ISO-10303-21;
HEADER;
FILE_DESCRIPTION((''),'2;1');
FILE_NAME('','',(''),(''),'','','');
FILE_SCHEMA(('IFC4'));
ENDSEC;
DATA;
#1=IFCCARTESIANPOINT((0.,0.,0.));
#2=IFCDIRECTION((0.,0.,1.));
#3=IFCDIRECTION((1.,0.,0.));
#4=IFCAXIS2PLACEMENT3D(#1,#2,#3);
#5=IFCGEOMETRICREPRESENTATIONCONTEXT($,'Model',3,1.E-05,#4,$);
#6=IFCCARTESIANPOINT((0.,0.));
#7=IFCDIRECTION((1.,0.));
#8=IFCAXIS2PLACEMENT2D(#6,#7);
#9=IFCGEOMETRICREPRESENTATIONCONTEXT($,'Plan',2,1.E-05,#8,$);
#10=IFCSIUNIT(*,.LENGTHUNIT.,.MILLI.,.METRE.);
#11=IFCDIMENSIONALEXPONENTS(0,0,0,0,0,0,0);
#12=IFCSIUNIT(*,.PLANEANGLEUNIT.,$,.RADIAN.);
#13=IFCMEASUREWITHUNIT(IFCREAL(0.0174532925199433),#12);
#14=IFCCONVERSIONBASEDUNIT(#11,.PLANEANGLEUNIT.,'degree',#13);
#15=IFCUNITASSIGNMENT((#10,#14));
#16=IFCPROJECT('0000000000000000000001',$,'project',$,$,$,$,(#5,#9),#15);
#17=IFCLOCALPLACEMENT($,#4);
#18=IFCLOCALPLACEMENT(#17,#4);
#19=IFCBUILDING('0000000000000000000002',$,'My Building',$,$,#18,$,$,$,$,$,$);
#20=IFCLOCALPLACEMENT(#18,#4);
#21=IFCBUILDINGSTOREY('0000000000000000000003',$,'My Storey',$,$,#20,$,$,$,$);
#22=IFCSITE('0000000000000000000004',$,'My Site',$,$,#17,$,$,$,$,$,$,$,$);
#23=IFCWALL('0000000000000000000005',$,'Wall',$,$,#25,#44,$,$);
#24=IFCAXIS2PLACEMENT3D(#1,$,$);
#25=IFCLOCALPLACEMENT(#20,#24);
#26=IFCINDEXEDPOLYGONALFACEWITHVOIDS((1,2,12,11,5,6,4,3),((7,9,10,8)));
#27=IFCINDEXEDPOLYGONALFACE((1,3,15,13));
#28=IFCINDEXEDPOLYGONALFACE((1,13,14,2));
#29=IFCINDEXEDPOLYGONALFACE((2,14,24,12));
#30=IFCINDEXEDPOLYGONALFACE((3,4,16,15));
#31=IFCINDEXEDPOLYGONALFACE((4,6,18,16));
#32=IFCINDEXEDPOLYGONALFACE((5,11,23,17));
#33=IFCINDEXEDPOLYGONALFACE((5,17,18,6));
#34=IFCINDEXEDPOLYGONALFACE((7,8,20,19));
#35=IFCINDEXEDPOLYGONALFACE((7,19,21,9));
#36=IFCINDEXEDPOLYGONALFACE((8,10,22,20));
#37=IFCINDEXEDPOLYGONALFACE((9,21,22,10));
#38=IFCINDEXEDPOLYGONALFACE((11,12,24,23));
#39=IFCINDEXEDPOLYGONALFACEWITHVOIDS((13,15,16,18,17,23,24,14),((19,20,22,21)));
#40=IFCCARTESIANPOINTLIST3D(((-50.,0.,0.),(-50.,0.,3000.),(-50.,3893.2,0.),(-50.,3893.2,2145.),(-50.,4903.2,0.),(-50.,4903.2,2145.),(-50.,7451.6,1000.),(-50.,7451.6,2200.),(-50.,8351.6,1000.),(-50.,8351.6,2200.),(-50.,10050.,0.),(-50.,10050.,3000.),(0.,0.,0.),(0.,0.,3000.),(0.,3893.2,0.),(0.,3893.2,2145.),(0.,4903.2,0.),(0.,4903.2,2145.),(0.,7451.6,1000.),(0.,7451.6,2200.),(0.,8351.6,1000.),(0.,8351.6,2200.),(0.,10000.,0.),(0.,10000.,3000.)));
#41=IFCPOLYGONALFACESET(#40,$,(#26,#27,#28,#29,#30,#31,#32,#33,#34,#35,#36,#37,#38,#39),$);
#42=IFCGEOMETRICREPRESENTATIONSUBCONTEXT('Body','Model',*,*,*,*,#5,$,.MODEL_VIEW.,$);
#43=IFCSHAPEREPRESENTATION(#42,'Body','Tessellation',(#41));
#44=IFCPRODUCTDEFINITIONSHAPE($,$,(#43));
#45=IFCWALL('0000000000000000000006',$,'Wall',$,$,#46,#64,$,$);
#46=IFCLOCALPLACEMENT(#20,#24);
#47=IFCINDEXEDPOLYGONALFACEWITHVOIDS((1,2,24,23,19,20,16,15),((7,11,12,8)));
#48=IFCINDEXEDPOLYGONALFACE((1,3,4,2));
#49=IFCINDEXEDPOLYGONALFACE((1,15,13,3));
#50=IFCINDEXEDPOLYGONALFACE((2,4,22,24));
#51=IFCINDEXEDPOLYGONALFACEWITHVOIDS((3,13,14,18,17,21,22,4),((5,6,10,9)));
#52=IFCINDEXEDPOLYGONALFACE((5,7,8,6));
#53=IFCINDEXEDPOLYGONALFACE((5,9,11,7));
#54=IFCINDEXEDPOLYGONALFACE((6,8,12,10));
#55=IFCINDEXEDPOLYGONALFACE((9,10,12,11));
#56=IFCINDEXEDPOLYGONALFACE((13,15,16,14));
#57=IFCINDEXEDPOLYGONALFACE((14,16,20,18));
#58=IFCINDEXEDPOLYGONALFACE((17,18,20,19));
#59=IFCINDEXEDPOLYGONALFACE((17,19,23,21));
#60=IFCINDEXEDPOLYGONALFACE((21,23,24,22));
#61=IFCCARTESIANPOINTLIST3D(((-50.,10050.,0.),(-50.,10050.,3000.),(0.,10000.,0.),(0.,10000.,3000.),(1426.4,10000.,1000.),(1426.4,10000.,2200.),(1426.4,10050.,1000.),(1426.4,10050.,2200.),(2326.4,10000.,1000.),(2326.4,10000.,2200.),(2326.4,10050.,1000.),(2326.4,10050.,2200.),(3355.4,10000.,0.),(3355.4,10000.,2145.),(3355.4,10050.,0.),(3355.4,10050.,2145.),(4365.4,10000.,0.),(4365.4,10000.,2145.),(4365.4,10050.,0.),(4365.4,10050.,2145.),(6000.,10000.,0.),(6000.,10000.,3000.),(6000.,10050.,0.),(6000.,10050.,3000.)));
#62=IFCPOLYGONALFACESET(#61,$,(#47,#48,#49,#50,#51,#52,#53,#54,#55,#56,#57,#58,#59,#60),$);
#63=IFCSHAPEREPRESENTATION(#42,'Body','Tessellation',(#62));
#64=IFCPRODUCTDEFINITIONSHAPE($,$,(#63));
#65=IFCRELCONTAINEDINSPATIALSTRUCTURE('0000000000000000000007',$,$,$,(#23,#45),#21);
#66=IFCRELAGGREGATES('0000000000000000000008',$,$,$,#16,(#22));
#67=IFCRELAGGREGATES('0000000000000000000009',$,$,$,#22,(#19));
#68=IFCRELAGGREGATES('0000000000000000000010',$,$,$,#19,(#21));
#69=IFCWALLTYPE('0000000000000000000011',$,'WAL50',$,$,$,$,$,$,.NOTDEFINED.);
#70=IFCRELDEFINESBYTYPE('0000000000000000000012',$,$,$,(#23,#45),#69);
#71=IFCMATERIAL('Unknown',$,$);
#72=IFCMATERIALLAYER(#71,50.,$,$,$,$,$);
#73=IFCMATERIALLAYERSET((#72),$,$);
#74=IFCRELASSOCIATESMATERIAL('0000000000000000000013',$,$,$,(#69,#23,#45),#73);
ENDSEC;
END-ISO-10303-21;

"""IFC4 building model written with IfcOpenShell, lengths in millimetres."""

from ifc_helpers import new_model, entity, si_unit, converted_unit, frame, origin_with_axes, origin_2d_with_axis, place, context, subcontext, project, spatial, line, indexed_curve, outline, extrude, source, transform, mapped, material, layer, layer_set, layer_usage, type_object, element, save


model = new_model("IFC4")

# Units and contexts
model_context = context("Model", 3, precision=1e-05, world=origin_with_axes())
plan_context = context("Plan", 2, precision=1e-05, world=origin_2d_with_axis())
body_context = subcontext(model_context, "Body", "Model", "MODEL_VIEW")
ifc_project = project(units=[si_unit("LENGTHUNIT", "METRE", prefix="MILLI"), converted_unit("PLANEANGLEUNIT", "degree", entity("IfcReal", 0.0174532925199433), si_unit("PLANEANGLEUNIT", "RADIAN"), dimensions=[0, 0, 0, 0, 0, 0, 0])], contexts=[model_context, plan_context])

# Site, building, storey
site_placement = place(None, origin_with_axes())
site = spatial("IfcSite", under=ifc_project, at=site_placement, Name="My Site")
building_placement = place(site_placement, origin_with_axes())
building = spatial("IfcBuilding", under=site, at=building_placement, Name="My Building")
storey_placement = place(building_placement, origin_with_axes())
storey = spatial("IfcBuildingStorey", under=building, at=storey_placement, Name="My Storey")

# Walls, openings
ifc_material = material(Name="Unknown")
ifc_layer = layer(ifc_material, 50.0)
ifc_layer_set = layer_set([ifc_layer])
ifc_layer_usage_1 = layer_usage(ifc_layer_set, "AXIS2", "POSITIVE", 0.0)
wall_type = type_object("IfcWallType", Name="WAL50", PredefinedType="NOTDEFINED", material=ifc_layer_set)
wall_1_placement = place(storey_placement, frame((0.0, 0.0, 0.0), z_axis=(0.0, 0.0, 1.0), x_axis=(0.0, 1.0, 0.0)))
wall_1 = element("IfcWall", 1, at=wall_1_placement, inside=storey, type_object=wall_type, material=ifc_layer_usage_1, Name="Wall", context=body_context, shape_type="SweptSolid", body=[
    extrude(outline(indexed_curve([(0.0, 0.0), (0.0, 50.0), (10050.0, 50.0), (10000.0, 0.0)], segments=[line(1, 2, 3, 4, 1)])), origin_with_axes(), (0.0, 0.0, 1.0), 3000.0),
])
shared_shape_1 = source(origin_with_axes(), body_context, "Body", "SweptSolid", [
    extrude(outline(indexed_curve([(0.0, 0.0), (1010.0, 0.0), (1010.0, 2145.0), (0.0, 2145.0)], segments=[line(1, 2, 3, 4, 1)])), frame((0.0, -600.0, 0.0), z_axis=(0.0, -1.0, 0.0), x_axis=(1.0, 0.0, 0.0)), (0.0, 0.0, -1.0), 1200.0),
])
opening_1_placement = place(wall_1_placement, frame((3893.2, 0.0, 0.0), z_axis=(0.0, 0.0, 1.0), x_axis=(1.0, 0.0, 0.0)))
element("IfcOpeningElement", 2, at=opening_1_placement, cuts=wall_1, PredefinedType="OPENING", context=body_context, shape_type="MappedRepresentation", body=[
    mapped(shared_shape_1, transform((0.0, 0.0, 0.0), x_axis=(1.0, 0.0, 0.0), y_axis=(0.0, 1.0, 0.0), z_axis=(0.0, 0.0, 1.0), scale=1.0)),
])
shared_shape_2 = source(origin_with_axes(), body_context, "Body", "SweptSolid", [
    extrude(outline(indexed_curve([(0.0, 0.0), (900.0, 0.0), (900.0, 1200.0), (0.0, 1200.0)], segments=[line(1, 2, 3, 4, 1)])), frame((0.0, -600.0, 0.0), z_axis=(0.0, -1.0, 0.0), x_axis=(1.0, 0.0, 0.0)), (0.0, 0.0, -1.0), 1200.0),
])
opening_2_placement = place(wall_1_placement, frame((7451.6, 0.0, 1000.0), z_axis=(0.0, 0.0, 1.0), x_axis=(1.0, 0.0, 0.0)))
element("IfcOpeningElement", 3, at=opening_2_placement, cuts=wall_1, PredefinedType="OPENING", context=body_context, shape_type="MappedRepresentation", body=[
    mapped(shared_shape_2, transform((0.0, 0.0, 0.0), x_axis=(1.0, 0.0, 0.0), y_axis=(0.0, 1.0, 0.0), z_axis=(0.0, 0.0, 1.0), scale=1.0)),
])
ifc_layer_usage_2 = layer_usage(ifc_layer_set, "AXIS2", "POSITIVE", 0.0)
wall_2_placement = place(storey_placement, frame((0.0, 10000.0, 0.0), z_axis=(0.0, 0.0, 1.0), x_axis=(1.0, 0.0, 0.0)))
wall_2 = element("IfcWall", 4, at=wall_2_placement, inside=storey, type_object=wall_type, material=ifc_layer_usage_2, Name="Wall", context=body_context, shape_type="SweptSolid", body=[
    extrude(outline(indexed_curve([(0.0, 0.0), (-50.0, 50.0), (6000.0, 50.0), (6000.0, 0.0)], segments=[line(1, 2, 3, 4, 1)])), origin_with_axes(), (0.0, 0.0, 1.0), 3000.0),
])
opening_3_placement = place(wall_2_placement, frame((3355.4, 0.0, 0.0), z_axis=(0.0, 0.0, 1.0), x_axis=(1.0, 0.0, 0.0)))
element("IfcOpeningElement", 5, at=opening_3_placement, cuts=wall_2, PredefinedType="OPENING", context=body_context, shape_type="MappedRepresentation", body=[
    mapped(shared_shape_1, transform((0.0, 0.0, 0.0), x_axis=(1.0, 0.0, 0.0), y_axis=(0.0, 1.0, 0.0), z_axis=(0.0, 0.0, 1.0), scale=1.0)),
])
opening_4_placement = place(wall_2_placement, frame((1426.4, 0.0, 1000.0), z_axis=(0.0, 0.0, 1.0), x_axis=(1.0, 0.0, 0.0)))
element("IfcOpeningElement", 6, at=opening_4_placement, cuts=wall_2, PredefinedType="OPENING", context=body_context, shape_type="MappedRepresentation", body=[
    mapped(shared_shape_2, transform((0.0, 0.0, 0.0), x_axis=(1.0, 0.0, 0.0), y_axis=(0.0, 1.0, 0.0), z_axis=(0.0, 0.0, 1.0), scale=1.0)),
])

save(model, "model.ifc")
